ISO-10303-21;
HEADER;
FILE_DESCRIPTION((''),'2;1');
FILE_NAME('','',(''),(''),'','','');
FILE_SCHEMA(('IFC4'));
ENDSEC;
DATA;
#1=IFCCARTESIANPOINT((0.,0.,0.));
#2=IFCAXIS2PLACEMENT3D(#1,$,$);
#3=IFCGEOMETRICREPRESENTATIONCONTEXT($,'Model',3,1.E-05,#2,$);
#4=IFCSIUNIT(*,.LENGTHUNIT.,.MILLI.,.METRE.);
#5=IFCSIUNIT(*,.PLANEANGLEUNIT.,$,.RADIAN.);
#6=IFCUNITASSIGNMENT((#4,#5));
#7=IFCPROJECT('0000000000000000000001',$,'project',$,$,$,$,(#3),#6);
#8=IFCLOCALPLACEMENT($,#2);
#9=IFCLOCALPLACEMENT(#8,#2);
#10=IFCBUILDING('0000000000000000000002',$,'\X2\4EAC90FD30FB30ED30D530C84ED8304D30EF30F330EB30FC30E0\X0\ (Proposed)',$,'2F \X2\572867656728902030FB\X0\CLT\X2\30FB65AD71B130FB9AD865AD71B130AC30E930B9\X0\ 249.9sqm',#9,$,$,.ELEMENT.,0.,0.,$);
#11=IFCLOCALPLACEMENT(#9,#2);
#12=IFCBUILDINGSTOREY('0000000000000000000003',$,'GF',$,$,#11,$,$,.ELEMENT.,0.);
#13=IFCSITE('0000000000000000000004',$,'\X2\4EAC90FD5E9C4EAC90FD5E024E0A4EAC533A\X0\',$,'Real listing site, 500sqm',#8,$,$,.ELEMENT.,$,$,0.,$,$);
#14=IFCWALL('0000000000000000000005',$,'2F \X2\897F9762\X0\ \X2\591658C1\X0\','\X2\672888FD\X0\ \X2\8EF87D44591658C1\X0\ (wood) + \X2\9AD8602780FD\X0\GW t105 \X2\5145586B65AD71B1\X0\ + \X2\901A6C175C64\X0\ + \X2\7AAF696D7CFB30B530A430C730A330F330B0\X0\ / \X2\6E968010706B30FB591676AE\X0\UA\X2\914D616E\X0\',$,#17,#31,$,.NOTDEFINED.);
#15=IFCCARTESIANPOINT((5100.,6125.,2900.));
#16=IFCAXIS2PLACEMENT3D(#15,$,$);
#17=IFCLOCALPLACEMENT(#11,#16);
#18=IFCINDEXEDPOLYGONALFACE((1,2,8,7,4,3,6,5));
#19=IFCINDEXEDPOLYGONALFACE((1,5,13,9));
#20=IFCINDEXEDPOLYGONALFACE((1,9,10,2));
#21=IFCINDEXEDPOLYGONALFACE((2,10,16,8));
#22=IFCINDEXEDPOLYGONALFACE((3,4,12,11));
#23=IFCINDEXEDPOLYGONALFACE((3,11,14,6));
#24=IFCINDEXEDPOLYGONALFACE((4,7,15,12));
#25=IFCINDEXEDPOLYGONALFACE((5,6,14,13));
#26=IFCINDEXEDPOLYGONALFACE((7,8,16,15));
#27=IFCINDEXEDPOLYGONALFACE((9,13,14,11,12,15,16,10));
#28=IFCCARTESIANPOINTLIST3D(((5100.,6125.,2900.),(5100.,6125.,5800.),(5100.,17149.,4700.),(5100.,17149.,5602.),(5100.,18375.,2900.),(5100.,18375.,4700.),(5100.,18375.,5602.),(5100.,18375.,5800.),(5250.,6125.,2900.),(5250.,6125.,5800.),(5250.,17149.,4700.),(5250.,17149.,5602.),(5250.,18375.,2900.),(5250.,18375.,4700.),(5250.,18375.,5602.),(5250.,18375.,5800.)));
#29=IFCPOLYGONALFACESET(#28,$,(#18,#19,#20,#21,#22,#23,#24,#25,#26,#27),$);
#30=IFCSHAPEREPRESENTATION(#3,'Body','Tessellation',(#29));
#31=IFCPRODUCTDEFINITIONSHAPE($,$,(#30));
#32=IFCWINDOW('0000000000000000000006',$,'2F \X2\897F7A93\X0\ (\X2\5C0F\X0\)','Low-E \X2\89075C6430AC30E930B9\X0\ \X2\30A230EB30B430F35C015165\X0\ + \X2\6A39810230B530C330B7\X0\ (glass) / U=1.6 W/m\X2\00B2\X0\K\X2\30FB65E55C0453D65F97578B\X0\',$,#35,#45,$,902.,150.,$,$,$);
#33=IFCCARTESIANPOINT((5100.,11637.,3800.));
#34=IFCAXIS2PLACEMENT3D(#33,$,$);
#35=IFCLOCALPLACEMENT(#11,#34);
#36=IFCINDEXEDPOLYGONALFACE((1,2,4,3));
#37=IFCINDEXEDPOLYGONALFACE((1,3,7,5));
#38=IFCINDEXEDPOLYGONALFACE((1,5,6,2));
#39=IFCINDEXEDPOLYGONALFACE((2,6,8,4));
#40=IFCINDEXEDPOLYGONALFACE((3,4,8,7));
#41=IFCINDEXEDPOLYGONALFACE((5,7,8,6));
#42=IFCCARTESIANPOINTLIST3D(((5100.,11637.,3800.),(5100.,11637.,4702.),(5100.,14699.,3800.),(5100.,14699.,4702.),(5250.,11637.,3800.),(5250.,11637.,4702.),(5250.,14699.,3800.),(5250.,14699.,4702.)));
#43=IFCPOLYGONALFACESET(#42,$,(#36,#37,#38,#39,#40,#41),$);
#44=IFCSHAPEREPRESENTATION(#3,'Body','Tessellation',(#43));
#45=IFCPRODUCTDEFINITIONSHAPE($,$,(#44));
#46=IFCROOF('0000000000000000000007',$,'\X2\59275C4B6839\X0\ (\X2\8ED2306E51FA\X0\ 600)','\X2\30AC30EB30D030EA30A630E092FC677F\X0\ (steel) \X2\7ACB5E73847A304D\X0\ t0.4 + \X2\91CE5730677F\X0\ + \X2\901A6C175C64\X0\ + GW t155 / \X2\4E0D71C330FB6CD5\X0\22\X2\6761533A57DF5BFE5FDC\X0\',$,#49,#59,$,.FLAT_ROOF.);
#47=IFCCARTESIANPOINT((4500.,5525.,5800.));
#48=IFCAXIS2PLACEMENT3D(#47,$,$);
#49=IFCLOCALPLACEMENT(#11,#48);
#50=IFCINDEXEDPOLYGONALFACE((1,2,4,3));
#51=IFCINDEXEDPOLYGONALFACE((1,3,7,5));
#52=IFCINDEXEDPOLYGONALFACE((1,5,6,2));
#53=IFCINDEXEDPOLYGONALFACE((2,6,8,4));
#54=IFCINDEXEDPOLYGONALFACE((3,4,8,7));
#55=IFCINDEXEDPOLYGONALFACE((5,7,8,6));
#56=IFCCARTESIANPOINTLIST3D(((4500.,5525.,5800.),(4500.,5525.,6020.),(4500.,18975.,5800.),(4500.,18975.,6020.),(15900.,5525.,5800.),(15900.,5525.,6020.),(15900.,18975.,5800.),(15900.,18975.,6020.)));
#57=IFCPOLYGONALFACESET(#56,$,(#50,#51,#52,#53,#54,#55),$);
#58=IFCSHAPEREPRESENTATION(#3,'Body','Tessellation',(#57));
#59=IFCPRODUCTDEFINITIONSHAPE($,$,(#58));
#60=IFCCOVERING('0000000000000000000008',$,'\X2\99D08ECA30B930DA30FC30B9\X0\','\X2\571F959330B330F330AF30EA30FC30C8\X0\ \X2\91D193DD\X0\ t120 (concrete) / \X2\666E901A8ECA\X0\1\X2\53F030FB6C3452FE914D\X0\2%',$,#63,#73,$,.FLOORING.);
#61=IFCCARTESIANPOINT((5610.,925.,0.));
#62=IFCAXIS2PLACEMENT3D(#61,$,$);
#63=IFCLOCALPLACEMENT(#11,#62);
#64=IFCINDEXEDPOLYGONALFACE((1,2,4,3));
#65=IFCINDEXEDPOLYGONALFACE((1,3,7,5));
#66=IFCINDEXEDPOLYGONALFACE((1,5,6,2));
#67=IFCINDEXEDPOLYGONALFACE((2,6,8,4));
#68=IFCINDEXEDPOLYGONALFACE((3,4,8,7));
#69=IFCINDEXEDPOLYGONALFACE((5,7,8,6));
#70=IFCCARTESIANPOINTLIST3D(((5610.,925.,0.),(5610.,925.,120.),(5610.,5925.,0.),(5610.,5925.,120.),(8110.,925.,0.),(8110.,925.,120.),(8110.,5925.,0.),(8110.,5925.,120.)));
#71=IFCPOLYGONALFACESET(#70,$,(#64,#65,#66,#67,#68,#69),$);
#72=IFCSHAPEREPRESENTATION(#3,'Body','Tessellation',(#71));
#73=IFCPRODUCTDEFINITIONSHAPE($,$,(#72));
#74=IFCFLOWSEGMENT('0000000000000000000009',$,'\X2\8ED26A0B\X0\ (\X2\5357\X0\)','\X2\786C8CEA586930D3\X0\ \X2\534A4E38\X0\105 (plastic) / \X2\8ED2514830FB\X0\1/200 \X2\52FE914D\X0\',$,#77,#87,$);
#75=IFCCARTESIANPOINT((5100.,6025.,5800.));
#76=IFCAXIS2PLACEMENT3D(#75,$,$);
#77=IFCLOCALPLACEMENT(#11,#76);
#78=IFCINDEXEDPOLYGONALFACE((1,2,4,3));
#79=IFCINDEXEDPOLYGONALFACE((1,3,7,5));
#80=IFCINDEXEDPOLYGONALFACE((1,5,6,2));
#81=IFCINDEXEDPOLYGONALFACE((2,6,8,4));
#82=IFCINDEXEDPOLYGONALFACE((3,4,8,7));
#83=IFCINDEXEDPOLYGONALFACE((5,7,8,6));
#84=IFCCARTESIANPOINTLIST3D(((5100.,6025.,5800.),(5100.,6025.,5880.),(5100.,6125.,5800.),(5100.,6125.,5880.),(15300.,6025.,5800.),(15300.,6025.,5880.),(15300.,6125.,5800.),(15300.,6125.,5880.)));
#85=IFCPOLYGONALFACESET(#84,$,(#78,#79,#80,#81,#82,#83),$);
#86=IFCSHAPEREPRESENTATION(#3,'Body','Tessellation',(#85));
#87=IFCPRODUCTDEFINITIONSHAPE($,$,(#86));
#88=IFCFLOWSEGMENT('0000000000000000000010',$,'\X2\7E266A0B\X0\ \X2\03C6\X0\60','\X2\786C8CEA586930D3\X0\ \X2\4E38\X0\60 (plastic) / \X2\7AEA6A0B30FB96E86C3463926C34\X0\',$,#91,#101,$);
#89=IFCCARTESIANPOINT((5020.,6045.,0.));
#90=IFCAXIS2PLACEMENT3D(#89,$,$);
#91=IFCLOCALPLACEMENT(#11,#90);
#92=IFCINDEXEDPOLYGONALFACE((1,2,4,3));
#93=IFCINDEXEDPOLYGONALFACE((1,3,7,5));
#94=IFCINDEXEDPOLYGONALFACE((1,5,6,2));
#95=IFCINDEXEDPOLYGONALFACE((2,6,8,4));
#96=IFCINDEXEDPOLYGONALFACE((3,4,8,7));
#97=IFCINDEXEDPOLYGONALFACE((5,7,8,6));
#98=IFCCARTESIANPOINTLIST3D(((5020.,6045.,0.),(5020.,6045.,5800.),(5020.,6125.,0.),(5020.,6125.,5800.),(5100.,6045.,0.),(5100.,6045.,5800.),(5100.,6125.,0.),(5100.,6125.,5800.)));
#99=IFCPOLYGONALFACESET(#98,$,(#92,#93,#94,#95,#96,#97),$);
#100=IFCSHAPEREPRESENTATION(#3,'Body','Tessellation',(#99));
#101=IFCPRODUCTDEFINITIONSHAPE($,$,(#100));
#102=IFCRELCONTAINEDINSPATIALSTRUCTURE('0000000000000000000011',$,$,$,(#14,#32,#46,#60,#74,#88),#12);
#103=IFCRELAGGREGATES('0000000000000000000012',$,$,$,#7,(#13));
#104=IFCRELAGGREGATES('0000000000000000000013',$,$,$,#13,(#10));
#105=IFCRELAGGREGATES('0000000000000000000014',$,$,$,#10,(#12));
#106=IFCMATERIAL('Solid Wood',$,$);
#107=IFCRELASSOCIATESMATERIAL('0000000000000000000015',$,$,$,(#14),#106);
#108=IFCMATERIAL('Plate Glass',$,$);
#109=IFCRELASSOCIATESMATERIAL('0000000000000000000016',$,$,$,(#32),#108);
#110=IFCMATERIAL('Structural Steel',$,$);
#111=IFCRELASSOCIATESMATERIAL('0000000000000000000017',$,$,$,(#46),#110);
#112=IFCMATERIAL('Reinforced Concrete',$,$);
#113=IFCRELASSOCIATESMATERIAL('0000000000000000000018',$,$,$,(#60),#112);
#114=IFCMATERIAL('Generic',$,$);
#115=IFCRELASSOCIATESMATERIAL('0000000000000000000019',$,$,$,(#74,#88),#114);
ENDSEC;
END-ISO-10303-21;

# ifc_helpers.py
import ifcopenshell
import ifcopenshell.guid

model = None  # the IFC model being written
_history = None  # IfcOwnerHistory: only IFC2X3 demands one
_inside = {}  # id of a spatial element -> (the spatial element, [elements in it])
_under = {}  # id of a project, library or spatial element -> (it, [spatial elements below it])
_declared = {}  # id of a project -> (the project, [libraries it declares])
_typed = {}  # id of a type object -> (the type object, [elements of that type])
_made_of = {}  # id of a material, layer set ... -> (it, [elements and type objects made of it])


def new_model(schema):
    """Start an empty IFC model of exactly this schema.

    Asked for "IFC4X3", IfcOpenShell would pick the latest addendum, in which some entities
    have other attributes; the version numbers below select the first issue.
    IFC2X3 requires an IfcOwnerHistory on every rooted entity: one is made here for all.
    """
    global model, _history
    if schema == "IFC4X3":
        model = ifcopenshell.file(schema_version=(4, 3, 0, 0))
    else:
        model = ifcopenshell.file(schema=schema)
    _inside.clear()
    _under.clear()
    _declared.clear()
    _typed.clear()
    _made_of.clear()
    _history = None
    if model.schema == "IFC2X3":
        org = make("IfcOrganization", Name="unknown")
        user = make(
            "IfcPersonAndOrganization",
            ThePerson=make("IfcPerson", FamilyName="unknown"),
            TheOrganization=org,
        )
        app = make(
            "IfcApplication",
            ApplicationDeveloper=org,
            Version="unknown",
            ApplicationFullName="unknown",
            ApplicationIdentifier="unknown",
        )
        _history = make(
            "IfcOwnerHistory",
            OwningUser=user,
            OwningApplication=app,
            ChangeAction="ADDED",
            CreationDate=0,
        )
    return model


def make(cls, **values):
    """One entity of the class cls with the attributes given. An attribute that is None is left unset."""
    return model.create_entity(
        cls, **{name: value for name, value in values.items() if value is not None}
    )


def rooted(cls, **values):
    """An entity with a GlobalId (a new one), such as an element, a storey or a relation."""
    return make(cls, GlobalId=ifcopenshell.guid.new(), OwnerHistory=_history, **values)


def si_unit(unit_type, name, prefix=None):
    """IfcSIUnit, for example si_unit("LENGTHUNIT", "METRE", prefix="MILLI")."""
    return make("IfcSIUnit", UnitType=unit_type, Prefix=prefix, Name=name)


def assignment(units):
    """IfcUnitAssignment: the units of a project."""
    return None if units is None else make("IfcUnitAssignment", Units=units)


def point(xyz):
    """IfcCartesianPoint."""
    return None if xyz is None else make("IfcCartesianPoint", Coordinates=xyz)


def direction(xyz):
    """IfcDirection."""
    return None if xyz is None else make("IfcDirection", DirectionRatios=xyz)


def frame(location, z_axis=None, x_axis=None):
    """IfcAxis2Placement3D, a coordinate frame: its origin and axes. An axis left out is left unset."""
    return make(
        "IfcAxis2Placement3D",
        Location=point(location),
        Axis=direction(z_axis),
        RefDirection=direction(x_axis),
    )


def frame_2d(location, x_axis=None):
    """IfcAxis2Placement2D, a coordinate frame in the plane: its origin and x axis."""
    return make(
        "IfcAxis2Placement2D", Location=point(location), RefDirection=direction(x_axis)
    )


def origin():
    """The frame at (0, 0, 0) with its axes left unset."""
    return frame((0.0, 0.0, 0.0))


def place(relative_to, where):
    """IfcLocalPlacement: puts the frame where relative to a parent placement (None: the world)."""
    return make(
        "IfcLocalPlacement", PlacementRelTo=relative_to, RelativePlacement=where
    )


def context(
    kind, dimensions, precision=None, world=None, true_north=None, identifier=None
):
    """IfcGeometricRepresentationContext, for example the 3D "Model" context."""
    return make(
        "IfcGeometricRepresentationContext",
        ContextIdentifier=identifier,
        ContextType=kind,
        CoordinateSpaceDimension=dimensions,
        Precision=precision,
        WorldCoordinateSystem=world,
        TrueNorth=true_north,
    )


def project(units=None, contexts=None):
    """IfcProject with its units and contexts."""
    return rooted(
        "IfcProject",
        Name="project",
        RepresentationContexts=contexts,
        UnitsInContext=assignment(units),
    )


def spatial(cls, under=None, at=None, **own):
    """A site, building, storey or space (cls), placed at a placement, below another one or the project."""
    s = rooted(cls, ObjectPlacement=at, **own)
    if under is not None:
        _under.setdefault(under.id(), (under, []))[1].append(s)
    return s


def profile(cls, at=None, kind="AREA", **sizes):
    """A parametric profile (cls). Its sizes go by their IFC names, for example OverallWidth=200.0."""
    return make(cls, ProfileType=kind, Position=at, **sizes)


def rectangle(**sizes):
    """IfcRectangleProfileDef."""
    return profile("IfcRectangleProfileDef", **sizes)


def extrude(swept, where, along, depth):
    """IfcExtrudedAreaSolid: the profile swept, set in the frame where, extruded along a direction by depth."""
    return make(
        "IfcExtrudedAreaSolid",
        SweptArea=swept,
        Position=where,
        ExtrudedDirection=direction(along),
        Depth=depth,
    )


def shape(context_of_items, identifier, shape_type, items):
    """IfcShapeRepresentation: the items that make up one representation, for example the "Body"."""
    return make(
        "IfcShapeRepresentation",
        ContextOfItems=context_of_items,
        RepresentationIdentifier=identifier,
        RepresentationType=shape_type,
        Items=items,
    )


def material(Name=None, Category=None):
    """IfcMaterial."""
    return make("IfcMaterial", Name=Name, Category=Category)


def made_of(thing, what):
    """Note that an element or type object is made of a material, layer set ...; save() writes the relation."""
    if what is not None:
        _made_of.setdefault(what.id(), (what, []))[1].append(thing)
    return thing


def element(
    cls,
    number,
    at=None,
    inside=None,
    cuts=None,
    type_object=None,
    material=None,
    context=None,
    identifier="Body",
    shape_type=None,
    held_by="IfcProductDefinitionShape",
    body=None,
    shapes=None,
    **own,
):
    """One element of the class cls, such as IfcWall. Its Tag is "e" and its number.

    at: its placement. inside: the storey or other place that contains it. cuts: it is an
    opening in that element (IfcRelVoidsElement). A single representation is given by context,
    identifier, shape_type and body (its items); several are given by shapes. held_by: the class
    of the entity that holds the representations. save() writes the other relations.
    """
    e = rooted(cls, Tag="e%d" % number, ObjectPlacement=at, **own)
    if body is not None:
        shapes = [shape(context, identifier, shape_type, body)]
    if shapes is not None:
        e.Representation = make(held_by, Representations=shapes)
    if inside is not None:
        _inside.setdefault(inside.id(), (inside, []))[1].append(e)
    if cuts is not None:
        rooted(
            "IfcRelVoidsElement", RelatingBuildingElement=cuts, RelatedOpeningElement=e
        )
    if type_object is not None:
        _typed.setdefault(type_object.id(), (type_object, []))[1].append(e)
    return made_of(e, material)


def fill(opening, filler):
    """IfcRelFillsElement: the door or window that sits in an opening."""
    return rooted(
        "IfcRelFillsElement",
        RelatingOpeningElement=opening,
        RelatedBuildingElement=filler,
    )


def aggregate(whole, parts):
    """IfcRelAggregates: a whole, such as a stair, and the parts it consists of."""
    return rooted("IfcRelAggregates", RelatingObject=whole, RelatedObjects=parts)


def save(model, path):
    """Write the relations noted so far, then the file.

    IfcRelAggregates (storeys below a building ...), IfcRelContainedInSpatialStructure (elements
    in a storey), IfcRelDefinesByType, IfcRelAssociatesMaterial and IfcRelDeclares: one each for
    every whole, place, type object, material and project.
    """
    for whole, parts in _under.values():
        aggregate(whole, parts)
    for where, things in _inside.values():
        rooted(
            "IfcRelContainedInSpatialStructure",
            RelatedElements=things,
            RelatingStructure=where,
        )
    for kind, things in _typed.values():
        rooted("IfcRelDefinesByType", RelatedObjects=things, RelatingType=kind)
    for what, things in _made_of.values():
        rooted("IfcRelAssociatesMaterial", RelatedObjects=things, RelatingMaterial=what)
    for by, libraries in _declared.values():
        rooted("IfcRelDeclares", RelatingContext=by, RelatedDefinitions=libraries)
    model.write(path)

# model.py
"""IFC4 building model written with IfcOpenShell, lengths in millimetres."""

from ifc_helpers import new_model, si_unit, frame, frame_2d, origin, place, context, project, spatial, rectangle, extrude, material, element, fill, save


model = new_model("IFC4")

# Units and contexts
model_context = context("Model", 3, precision=1e-05, world=origin())
ifc_project = project(units=[si_unit("LENGTHUNIT", "METRE", prefix="MILLI"), si_unit("PLANEANGLEUNIT", "RADIAN")], contexts=[model_context])

# Site, building, storey
site_placement = place(None, origin())
site = spatial("IfcSite", under=ifc_project, at=site_placement, Name="京都府京都市上京区", ObjectType="Real listing site, 500sqm", CompositionType="ELEMENT", RefElevation=0.0)
building_placement = place(site_placement, origin())
building = spatial("IfcBuilding", under=site, at=building_placement, Name="京都・ロフト付きワンルーム (Proposed)", ObjectType="2F 在来木造・CLT・断熱・高断熱ガラス 249.9sqm", CompositionType="ELEMENT", ElevationOfRefHeight=0.0, ElevationOfTerrain=0.0)
storey_placement = place(building_placement, origin())
storey = spatial("IfcBuildingStorey", under=building, at=storey_placement, Name="GF", CompositionType="ELEMENT", Elevation=0.0)

# Shared definitions
ifc_material_1 = material(Name="Solid Wood")

# Shared definitions
ifc_material_2 = material(Name="Reinforced Concrete")

# Shared definitions
ifc_material_3 = material(Name="Plate Glass")

# Wall, opening, window
wall_1_placement = place(storey_placement, frame((5100.0, 6125.0, 2900.0)))
wall_1 = element("IfcWall", 1, at=wall_1_placement, inside=storey, material=ifc_material_1, Name="2F 西面 外壁", Description="木製 軸組外壁 (wood) + 高性能GW t105 充填断熱 + 通気層 + 窯業系サイディング / 準耐火・外皮UA配慮", PredefinedType="NOTDEFINED", context=model_context, shape_type="SweptSolid", body=[
    extrude(rectangle(XDim=150.0, YDim=12250.0, at=frame_2d((75.0, 6125.0))), frame((5100.0, 6125.0, 2900.0)), (0.0, 0.0, 1.0), 2900.0),
])
opening_1_placement = place(storey_placement, frame((5100.0, 11637.0, 3800.0)))
opening_1 = element("IfcOpeningElement", 2, at=opening_1_placement, cuts=wall_1, PredefinedType="NOTDEFINED", context=model_context, shape_type="SweptSolid", body=[
    extrude(rectangle(XDim=150.0, YDim=3062.0, at=frame_2d((75.0, 1531.0))), frame((5100.0, 11637.0, 3800.0)), (0.0, 0.0, 1.0), 902.0),
])
window_1_placement = place(storey_placement, frame((5100.0, 11637.0, 3800.0)))
window_1 = element("IfcWindow", 3, at=window_1_placement, inside=storey, material=ifc_material_3, Name="2F 西窓 (小)", Description="Low-E 複層ガラス アルゴン封入 + 樹脂サッシ (glass) / U=1.6 W/m²K・日射取得型", OverallHeight=902.0, OverallWidth=150.0, context=model_context, shape_type="SweptSolid", body=[
    extrude(rectangle(XDim=150.0, YDim=3062.0, at=frame_2d((75.0, 1531.0))), frame((5100.0, 11637.0, 3800.0)), (0.0, 0.0, 1.0), 902.0),
])
fill(opening_1, window_1)

# Roof
ifc_material_4 = material(Name="Structural Steel")
roof_placement = place(storey_placement, frame((4500.0, 5525.0, 5800.0)))
element("IfcRoof", 4, at=roof_placement, inside=storey, material=ifc_material_4, Name="大屋根 (軒の出 600)", Description="ガルバリウム鋼板 (steel) 立平葺き t0.4 + 野地板 + 通気層 + GW t155 / 不燃・法22条区域対応", PredefinedType="FLAT_ROOF", context=model_context, shape_type="SweptSolid", body=[
    extrude(rectangle(XDim=11400.0, YDim=13450.0, at=frame_2d((5700.0, 6725.0))), frame((4500.0, 5525.0, 5800.0)), (0.0, 0.0, 1.0), 220.0),
])

# Covering
covering_placement = place(storey_placement, frame((5610.0, 925.0, 0.0)))
element("IfcCovering", 5, at=covering_placement, inside=storey, material=ifc_material_2, Name="駐車スペース", Description="土間コンクリート 金鏝 t120 (concrete) / 普通車1台・水勾配2%", PredefinedType="FLOORING", context=model_context, shape_type="SweptSolid", body=[
    extrude(rectangle(XDim=2500.0, YDim=5000.0, at=frame_2d((1250.0, 2500.0))), frame((5610.0, 925.0, 0.0)), (0.0, 0.0, 1.0), 120.0),
])

# Flow segments
ifc_material_5 = material(Name="Generic")
flow_segment_1_placement = place(storey_placement, frame((5100.0, 6025.0, 5800.0)))
element("IfcFlowSegment", 6, at=flow_segment_1_placement, inside=storey, material=ifc_material_5, Name="軒樋 (南)", Description="硬質塩ビ 半丸105 (plastic) / 軒先・1/200 勾配", context=model_context, shape_type="SweptSolid", body=[
    extrude(rectangle(XDim=10200.0, YDim=100.0, at=frame_2d((5100.0, 50.0))), frame((5100.0, 6025.0, 5800.0)), (0.0, 0.0, 1.0), 80.0),
])
flow_segment_2_placement = place(storey_placement, frame((5020.0, 6045.0, 0.0)))
element("IfcFlowSegment", 7, at=flow_segment_2_placement, inside=storey, material=ifc_material_5, Name="縦樋 φ60", Description="硬質塩ビ 丸60 (plastic) / 竪樋・雨水排水", context=model_context, shape_type="SweptSolid", body=[
    extrude(rectangle(XDim=80.0, YDim=80.0, at=frame_2d((40.0, 40.0))), frame((5020.0, 6045.0, 0.0)), (0.0, 0.0, 1.0), 5800.0),
])

save(model, "model.ifc")
